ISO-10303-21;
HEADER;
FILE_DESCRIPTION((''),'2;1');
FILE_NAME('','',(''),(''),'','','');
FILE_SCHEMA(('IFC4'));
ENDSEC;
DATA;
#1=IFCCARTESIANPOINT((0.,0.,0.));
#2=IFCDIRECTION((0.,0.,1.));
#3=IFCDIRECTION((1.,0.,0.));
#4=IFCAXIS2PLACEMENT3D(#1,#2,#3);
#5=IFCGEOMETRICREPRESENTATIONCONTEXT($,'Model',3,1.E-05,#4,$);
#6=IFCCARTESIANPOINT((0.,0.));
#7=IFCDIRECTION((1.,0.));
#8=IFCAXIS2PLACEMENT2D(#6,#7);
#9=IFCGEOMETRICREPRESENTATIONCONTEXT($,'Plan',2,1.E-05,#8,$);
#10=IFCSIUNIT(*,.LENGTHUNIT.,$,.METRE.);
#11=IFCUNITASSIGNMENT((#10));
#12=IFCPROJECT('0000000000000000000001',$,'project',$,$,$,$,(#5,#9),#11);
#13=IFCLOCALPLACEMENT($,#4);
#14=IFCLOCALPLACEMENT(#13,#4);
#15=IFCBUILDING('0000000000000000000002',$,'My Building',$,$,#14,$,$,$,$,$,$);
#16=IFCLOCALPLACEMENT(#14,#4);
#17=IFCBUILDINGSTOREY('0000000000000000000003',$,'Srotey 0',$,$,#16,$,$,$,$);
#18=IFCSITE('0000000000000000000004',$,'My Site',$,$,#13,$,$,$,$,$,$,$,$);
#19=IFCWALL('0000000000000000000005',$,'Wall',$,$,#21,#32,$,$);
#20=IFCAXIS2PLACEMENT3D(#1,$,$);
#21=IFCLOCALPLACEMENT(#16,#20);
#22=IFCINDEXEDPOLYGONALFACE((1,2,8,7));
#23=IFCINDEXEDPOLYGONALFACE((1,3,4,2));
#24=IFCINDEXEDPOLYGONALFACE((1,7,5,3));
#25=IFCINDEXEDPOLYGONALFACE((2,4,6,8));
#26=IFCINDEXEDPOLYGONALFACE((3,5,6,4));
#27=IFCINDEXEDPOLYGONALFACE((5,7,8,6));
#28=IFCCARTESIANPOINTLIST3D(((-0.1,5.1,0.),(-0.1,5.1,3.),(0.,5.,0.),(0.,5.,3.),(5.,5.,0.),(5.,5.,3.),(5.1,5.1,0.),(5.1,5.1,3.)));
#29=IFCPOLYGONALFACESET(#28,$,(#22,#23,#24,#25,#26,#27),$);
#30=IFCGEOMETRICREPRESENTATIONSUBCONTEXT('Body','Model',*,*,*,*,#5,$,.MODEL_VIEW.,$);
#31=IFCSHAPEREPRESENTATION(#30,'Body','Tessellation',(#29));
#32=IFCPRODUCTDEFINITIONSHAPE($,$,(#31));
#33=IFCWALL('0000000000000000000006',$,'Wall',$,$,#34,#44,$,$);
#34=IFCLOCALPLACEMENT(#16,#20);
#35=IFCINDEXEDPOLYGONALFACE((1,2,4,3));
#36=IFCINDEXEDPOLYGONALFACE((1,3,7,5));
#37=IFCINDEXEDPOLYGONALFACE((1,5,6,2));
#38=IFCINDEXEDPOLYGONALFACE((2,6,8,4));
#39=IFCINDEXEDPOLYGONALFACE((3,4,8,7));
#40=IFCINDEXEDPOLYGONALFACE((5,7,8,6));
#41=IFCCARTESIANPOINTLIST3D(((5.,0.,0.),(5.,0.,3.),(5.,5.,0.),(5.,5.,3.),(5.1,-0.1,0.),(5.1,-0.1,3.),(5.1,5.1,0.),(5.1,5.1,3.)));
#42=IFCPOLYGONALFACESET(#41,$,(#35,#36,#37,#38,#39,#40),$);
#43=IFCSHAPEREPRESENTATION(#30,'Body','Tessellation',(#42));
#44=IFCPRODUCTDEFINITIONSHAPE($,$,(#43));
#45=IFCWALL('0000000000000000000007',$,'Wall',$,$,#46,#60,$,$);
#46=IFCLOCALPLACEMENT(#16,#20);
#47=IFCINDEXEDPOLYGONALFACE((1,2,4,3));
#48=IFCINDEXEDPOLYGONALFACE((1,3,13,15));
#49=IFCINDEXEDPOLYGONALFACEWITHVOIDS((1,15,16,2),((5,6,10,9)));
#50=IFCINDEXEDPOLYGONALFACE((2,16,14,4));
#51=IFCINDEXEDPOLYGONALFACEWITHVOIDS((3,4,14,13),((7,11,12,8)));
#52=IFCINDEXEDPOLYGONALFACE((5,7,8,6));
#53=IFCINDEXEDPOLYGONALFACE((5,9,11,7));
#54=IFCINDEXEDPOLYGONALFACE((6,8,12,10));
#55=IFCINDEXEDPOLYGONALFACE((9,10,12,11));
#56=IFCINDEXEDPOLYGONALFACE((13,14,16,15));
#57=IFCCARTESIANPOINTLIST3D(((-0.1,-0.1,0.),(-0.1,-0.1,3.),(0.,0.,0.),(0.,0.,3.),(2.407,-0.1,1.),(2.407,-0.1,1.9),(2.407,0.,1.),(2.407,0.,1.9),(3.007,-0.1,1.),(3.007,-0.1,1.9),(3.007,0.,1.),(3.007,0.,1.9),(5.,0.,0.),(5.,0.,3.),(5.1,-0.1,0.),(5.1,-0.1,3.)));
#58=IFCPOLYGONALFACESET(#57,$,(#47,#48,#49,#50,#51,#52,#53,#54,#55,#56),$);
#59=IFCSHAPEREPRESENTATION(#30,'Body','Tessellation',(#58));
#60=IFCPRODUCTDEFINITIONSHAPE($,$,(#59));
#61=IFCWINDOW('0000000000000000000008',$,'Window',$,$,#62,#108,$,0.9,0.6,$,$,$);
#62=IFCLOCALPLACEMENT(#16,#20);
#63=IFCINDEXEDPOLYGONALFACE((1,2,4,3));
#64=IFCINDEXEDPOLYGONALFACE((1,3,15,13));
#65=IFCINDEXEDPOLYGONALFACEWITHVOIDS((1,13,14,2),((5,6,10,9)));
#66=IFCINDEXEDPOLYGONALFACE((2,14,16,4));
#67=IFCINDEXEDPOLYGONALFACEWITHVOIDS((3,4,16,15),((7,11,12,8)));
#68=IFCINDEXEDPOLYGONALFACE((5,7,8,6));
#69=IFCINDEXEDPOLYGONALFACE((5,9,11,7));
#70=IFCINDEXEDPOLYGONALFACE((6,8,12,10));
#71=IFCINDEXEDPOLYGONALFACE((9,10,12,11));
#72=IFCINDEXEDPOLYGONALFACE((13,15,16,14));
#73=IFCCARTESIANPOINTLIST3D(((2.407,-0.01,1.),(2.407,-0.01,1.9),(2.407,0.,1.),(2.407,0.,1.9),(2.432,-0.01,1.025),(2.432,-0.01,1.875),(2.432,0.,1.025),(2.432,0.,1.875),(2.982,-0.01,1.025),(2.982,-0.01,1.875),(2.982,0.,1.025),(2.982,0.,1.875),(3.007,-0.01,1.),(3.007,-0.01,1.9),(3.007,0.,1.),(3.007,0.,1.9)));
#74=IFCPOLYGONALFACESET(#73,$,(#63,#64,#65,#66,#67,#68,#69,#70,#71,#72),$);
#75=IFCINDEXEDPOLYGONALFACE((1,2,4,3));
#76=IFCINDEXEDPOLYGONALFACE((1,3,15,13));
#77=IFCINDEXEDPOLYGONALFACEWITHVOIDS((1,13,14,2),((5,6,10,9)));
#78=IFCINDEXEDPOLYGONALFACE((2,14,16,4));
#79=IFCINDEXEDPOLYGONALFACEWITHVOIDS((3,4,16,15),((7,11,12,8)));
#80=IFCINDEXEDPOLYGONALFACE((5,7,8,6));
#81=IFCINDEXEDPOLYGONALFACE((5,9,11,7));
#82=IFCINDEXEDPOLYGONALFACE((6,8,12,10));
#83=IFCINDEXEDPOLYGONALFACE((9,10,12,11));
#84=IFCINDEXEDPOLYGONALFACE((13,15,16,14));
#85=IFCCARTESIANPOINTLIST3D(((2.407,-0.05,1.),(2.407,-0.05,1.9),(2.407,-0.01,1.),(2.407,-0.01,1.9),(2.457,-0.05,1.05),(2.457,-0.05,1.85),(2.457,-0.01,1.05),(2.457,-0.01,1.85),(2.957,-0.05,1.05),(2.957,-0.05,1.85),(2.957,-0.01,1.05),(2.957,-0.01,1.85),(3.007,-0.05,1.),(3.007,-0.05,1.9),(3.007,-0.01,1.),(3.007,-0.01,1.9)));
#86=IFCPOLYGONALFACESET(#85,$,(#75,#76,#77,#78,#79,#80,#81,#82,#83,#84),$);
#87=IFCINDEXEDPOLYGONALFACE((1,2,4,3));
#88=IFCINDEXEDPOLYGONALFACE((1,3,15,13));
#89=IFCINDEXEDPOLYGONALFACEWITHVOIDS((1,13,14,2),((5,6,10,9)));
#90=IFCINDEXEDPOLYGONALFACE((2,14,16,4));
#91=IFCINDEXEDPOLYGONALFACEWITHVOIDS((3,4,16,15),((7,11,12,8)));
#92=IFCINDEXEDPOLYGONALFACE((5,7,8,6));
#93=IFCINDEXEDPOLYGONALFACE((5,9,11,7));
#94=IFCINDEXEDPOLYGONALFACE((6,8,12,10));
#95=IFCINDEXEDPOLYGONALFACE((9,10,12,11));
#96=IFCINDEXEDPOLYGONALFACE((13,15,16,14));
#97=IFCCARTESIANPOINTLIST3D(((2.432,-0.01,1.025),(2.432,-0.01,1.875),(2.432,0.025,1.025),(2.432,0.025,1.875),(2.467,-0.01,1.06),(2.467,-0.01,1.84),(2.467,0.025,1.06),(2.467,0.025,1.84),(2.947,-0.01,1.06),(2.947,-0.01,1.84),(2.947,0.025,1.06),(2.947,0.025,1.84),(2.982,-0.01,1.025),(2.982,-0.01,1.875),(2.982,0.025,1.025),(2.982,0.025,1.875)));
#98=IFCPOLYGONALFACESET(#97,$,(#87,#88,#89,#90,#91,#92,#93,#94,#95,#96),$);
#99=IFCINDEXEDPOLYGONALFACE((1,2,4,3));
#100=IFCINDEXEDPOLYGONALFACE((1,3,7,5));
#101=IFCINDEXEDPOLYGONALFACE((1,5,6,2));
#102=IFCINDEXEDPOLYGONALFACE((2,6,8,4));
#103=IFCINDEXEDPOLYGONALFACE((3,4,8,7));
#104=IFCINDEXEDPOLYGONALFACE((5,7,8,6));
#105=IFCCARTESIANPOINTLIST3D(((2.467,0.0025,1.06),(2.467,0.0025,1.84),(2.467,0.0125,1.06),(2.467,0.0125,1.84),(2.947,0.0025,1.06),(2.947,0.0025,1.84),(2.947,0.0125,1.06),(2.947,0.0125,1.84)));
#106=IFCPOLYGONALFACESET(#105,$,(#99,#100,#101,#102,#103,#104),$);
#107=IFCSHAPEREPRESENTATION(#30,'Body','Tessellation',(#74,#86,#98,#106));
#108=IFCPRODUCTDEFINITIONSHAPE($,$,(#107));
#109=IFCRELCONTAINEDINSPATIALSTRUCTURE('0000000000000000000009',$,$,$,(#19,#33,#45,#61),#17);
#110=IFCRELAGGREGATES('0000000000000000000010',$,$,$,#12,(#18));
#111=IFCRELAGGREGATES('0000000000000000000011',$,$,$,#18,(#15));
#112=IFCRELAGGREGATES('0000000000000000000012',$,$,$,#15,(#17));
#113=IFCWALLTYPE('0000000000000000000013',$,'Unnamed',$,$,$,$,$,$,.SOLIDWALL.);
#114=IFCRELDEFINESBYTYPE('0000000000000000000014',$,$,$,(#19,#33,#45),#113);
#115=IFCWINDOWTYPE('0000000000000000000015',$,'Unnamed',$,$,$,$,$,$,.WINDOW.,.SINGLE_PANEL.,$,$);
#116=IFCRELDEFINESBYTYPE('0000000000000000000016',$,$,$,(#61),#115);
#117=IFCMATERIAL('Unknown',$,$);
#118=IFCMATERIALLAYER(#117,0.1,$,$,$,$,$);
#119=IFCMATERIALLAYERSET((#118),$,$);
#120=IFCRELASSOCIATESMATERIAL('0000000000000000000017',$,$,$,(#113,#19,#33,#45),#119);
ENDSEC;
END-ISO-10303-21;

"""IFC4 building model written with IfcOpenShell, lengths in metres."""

from ifc_helpers import new_model, entity, si_unit, frame, origin_with_axes, origin_2d_with_axis, place, context, subcontext, project, spatial, line, indexed_curve, outline, extrude, shape, source, transform, mapped, material, layer, layer_set, layer_usage, type_object, type_shapes, element, fill, save


model = new_model("IFC4")

# Units and contexts
model_context = context("Model", 3, precision=1e-05, world=origin_with_axes())
plan_context = context("Plan", 2, precision=1e-05, world=origin_2d_with_axis())
body_context_1 = subcontext(model_context, "Body", "Model", "MODEL_VIEW")
body_context_2 = subcontext(plan_context, "Body", "Plan", "PLAN_VIEW")
ifc_project = project(units=[si_unit("LENGTHUNIT", "METRE")], contexts=[model_context, plan_context])

# Site, building, storey
site_placement = place(None, origin_with_axes())
site = spatial("IfcSite", under=ifc_project, at=site_placement, Name="My Site")
building_placement = place(site_placement, origin_with_axes())
building = spatial("IfcBuilding", under=site, at=building_placement, Name="My Building")
storey_placement = place(building_placement, origin_with_axes())
storey = spatial("IfcBuildingStorey", under=building, at=storey_placement, Name="Srotey 0")

# Walls
ifc_material = material(Name="Unknown")
ifc_layer = layer(ifc_material, 0.1)
ifc_layer_set = layer_set([ifc_layer])
ifc_layer_usage_1 = layer_usage(ifc_layer_set, "AXIS2", "POSITIVE", 0.0)
wall_type = type_object("IfcWallType", Name="Unnamed", PredefinedType="SOLIDWALL", material=ifc_layer_set)
wall_1_placement = place(storey_placement, frame((0.0, 5.0, 0.0), z_axis=(0.0, 0.0, 1.0), x_axis=(1.0, 0.0, 0.0)))
element("IfcWall", 1, at=wall_1_placement, inside=storey, type_object=wall_type, material=ifc_layer_usage_1, Name="Wall", context=body_context_1, shape_type="SweptSolid", body=[
    extrude(outline(indexed_curve([(0.0, 0.0), (-0.1, 0.1), (5.1, 0.1), (5.0, 0.0)], segments=[line(1, 2, 3, 4, 1)])), origin_with_axes(), (0.0, 0.0, 1.0), 3.0),
])
ifc_layer_usage_2 = layer_usage(ifc_layer_set, "AXIS2", "POSITIVE", 0.0)
wall_2_placement = place(storey_placement, frame((5.0, 5.0, 0.0), z_axis=(0.0, 0.0, 1.0), x_axis=(0.0, -1.0, 0.0)))
element("IfcWall", 2, at=wall_2_placement, inside=storey, type_object=wall_type, material=ifc_layer_usage_2, Name="Wall", context=body_context_1, shape_type="SweptSolid", body=[
    extrude(outline(indexed_curve([(0.0, 0.0), (-0.1, 0.1), (5.1, 0.1), (5.0, 0.0)], segments=[line(1, 2, 3, 4, 1)])), origin_with_axes(), (0.0, 0.0, 1.0), 3.0),
])

# Wall, opening, window
ifc_layer_usage_3 = layer_usage(ifc_layer_set, "AXIS2", "POSITIVE", 0.0)
wall_3_placement = place(storey_placement, frame((5.0, 0.0, 0.0), z_axis=(0.0, 0.0, 1.0), x_axis=(-1.0, 0.0, 0.0)))
wall_3 = element("IfcWall", 3, at=wall_3_placement, inside=storey, type_object=wall_type, material=ifc_layer_usage_3, Name="Wall", context=body_context_1, shape_type="SweptSolid", body=[
    extrude(outline(indexed_curve([(0.0, 0.0), (-0.1, 0.1), (5.1, 0.1), (5.0, 0.0)], segments=[line(1, 2, 3, 4, 1)])), origin_with_axes(), (0.0, 0.0, 1.0), 3.0),
])
shared_shape_1 = source(origin_with_axes(), body_context_1, "Body", "SweptSolid", [
    extrude(outline(indexed_curve([(0.0, 0.0), (0.6, 0.0), (0.6, 0.9), (0.0, 0.9)], segments=[line(1, 2, 3, 4, 1)])), frame((0.0, -0.6, 0.0), z_axis=(0.0, -1.0, 0.0), x_axis=(1.0, 0.0, 0.0)), (0.0, 0.0, -1.0), 1.2),
])
opening_1_placement = place(wall_3_placement, frame((2.593, 0.1, 1.0), z_axis=(0.0, 0.0, 1.0), x_axis=(-1.0, 0.0, 0.0)))
opening_1 = element("IfcOpeningElement", 4, at=opening_1_placement, cuts=wall_3, PredefinedType="OPENING", context=body_context_1, shape_type="MappedRepresentation", body=[
    mapped(shared_shape_1, transform((0.0, 0.0, 0.0), x_axis=(1.0, 0.0, 0.0), y_axis=(0.0, 1.0, 0.0), z_axis=(0.0, 0.0, 1.0), scale=1.0)),
])
window_type = type_object("IfcWindowType", Name="Unnamed", PartitioningType="SINGLE_PANEL", PredefinedType="WINDOW")
shared_shape_2 = source(origin_with_axes(), body_context_1, "Body", "SweptSolid", [
    extrude(outline(indexed_curve([(0.0, 0.0), (0.6, 0.0), (0.6, 0.9), (0.0, 0.9)], segments=[line(1, 2, 3, 4, 1)]), holes=[indexed_curve([(0.025, 0.025), (0.575, 0.025), (0.575, 0.875), (0.025, 0.875)], segments=[line(1, 2, 3, 4, 1)])]), frame((0.0, 0.09, 0.0), z_axis=(0.0, -1.0, 0.0), x_axis=(1.0, 0.0, 0.0)), (0.0, 0.0, -1.0), 0.01),
    extrude(outline(indexed_curve([(0.0, 0.0), (0.6, 0.0), (0.6, 0.9), (0.0, 0.9)], segments=[line(1, 2, 3, 4, 1)]), holes=[indexed_curve([(0.05, 0.05), (0.55, 0.05), (0.55, 0.85), (0.05, 0.85)], segments=[line(1, 2, 3, 4, 1)])]), frame((0.0, 0.05, 0.0), z_axis=(0.0, -1.0, 0.0), x_axis=(1.0, 0.0, 0.0)), (0.0, 0.0, -1.0), 0.04),
    extrude(outline(indexed_curve([(0.0, 0.0), (0.55, 0.0), (0.55, 0.85), (0.0, 0.85)], segments=[line(1, 2, 3, 4, 1)]), holes=[indexed_curve([(0.035, 0.035), (0.515, 0.035), (0.515, 0.815), (0.035, 0.815)], segments=[line(1, 2, 3, 4, 1)])]), frame((0.025, 0.09, 0.025), z_axis=(0.0, -1.0, 0.0), x_axis=(1.0, 0.0, 0.0)), (0.0, 0.0, -1.0), 0.035),
    extrude(outline(indexed_curve([(0.035, 0.035), (0.515, 0.035), (0.515, 0.815), (0.035, 0.815)], segments=[line(1, 2, 3, 4, 1)])), frame((0.025, 0.1025, 0.025), z_axis=(0.0, -1.0, 0.0), x_axis=(1.0, 0.0, 0.0)), (0.0, 0.0, -1.0), 0.01),
])
shared_shape_3 = source(origin_with_axes(), body_context_2, "Body", "Curve2D", [
    entity("IfcIndexedPolyCurve", entity("IfcCartesianPointList2D", [[0.05, 0.05], [0.55, 0.05]])),
    entity("IfcIndexedPolyCurve", entity("IfcCartesianPointList2D", [[0.0, 0.1], [0.025, 0.1], [0.025, 0.09], [0.05, 0.09], [0.05, 0.05], [0.0, 0.05]]), [entity("IfcLineIndex", [1, 2, 3, 4, 5, 6, 1])]),
    entity("IfcIndexedPolyCurve", entity("IfcCartesianPointList2D", [[0.6, 0.1], [0.575, 0.1], [0.575, 0.09], [0.55, 0.09], [0.55, 0.05], [0.6, 0.05]]), [entity("IfcLineIndex", [1, 2, 3, 4, 5, 6, 1])]),
    entity("IfcIndexedPolyCurve", entity("IfcCartesianPointList2D", [[0.025, 0.09], [0.06, 0.09], [0.06, 0.125], [0.025, 0.125]]), [entity("IfcLineIndex", [1, 2, 3, 4, 1])]),
    entity("IfcIndexedPolyCurve", entity("IfcCartesianPointList2D", [[0.575, 0.09], [0.54, 0.09], [0.54, 0.125], [0.575, 0.125]]), [entity("IfcLineIndex", [1, 2, 3, 4, 1])]),
    entity("IfcIndexedPolyCurve", entity("IfcCartesianPointList2D", [[0.06, 0.09], [0.54, 0.09]])),
    entity("IfcIndexedPolyCurve", entity("IfcCartesianPointList2D", [[0.06, 0.125], [0.54, 0.125]])),
    entity("IfcIndexedPolyCurve", entity("IfcCartesianPointList2D", [[0.06, 0.1075], [0.54, 0.1075]])),
])
type_shapes(window_type, [shared_shape_2, shared_shape_3])
window_1_placement = place(opening_1_placement, frame((0.0, 0.0, 0.0), z_axis=(0.0, 0.0, 1.0), x_axis=(1.0, 0.0, 0.0)))
window_1 = element("IfcWindow", 5, at=window_1_placement, inside=storey, type_object=window_type, Name="Window", OverallHeight=0.9, OverallWidth=0.6, shapes=[
    shape(body_context_1, "Body", "MappedRepresentation", [mapped(shared_shape_2, transform((0.0, 0.0, 0.0), x_axis=(1.0, 0.0, 0.0), y_axis=(0.0, 1.0, 0.0), z_axis=(0.0, 0.0, 1.0), scale=1.0))]),
    shape(body_context_2, "Body", "MappedRepresentation", [mapped(shared_shape_3, transform((0.0, 0.0, 0.0), x_axis=(1.0, 0.0, 0.0), y_axis=(0.0, 1.0, 0.0), z_axis=(0.0, 0.0, 1.0), scale=1.0))]),
])
fill(opening_1, window_1)

save(model, "model.ifc")
